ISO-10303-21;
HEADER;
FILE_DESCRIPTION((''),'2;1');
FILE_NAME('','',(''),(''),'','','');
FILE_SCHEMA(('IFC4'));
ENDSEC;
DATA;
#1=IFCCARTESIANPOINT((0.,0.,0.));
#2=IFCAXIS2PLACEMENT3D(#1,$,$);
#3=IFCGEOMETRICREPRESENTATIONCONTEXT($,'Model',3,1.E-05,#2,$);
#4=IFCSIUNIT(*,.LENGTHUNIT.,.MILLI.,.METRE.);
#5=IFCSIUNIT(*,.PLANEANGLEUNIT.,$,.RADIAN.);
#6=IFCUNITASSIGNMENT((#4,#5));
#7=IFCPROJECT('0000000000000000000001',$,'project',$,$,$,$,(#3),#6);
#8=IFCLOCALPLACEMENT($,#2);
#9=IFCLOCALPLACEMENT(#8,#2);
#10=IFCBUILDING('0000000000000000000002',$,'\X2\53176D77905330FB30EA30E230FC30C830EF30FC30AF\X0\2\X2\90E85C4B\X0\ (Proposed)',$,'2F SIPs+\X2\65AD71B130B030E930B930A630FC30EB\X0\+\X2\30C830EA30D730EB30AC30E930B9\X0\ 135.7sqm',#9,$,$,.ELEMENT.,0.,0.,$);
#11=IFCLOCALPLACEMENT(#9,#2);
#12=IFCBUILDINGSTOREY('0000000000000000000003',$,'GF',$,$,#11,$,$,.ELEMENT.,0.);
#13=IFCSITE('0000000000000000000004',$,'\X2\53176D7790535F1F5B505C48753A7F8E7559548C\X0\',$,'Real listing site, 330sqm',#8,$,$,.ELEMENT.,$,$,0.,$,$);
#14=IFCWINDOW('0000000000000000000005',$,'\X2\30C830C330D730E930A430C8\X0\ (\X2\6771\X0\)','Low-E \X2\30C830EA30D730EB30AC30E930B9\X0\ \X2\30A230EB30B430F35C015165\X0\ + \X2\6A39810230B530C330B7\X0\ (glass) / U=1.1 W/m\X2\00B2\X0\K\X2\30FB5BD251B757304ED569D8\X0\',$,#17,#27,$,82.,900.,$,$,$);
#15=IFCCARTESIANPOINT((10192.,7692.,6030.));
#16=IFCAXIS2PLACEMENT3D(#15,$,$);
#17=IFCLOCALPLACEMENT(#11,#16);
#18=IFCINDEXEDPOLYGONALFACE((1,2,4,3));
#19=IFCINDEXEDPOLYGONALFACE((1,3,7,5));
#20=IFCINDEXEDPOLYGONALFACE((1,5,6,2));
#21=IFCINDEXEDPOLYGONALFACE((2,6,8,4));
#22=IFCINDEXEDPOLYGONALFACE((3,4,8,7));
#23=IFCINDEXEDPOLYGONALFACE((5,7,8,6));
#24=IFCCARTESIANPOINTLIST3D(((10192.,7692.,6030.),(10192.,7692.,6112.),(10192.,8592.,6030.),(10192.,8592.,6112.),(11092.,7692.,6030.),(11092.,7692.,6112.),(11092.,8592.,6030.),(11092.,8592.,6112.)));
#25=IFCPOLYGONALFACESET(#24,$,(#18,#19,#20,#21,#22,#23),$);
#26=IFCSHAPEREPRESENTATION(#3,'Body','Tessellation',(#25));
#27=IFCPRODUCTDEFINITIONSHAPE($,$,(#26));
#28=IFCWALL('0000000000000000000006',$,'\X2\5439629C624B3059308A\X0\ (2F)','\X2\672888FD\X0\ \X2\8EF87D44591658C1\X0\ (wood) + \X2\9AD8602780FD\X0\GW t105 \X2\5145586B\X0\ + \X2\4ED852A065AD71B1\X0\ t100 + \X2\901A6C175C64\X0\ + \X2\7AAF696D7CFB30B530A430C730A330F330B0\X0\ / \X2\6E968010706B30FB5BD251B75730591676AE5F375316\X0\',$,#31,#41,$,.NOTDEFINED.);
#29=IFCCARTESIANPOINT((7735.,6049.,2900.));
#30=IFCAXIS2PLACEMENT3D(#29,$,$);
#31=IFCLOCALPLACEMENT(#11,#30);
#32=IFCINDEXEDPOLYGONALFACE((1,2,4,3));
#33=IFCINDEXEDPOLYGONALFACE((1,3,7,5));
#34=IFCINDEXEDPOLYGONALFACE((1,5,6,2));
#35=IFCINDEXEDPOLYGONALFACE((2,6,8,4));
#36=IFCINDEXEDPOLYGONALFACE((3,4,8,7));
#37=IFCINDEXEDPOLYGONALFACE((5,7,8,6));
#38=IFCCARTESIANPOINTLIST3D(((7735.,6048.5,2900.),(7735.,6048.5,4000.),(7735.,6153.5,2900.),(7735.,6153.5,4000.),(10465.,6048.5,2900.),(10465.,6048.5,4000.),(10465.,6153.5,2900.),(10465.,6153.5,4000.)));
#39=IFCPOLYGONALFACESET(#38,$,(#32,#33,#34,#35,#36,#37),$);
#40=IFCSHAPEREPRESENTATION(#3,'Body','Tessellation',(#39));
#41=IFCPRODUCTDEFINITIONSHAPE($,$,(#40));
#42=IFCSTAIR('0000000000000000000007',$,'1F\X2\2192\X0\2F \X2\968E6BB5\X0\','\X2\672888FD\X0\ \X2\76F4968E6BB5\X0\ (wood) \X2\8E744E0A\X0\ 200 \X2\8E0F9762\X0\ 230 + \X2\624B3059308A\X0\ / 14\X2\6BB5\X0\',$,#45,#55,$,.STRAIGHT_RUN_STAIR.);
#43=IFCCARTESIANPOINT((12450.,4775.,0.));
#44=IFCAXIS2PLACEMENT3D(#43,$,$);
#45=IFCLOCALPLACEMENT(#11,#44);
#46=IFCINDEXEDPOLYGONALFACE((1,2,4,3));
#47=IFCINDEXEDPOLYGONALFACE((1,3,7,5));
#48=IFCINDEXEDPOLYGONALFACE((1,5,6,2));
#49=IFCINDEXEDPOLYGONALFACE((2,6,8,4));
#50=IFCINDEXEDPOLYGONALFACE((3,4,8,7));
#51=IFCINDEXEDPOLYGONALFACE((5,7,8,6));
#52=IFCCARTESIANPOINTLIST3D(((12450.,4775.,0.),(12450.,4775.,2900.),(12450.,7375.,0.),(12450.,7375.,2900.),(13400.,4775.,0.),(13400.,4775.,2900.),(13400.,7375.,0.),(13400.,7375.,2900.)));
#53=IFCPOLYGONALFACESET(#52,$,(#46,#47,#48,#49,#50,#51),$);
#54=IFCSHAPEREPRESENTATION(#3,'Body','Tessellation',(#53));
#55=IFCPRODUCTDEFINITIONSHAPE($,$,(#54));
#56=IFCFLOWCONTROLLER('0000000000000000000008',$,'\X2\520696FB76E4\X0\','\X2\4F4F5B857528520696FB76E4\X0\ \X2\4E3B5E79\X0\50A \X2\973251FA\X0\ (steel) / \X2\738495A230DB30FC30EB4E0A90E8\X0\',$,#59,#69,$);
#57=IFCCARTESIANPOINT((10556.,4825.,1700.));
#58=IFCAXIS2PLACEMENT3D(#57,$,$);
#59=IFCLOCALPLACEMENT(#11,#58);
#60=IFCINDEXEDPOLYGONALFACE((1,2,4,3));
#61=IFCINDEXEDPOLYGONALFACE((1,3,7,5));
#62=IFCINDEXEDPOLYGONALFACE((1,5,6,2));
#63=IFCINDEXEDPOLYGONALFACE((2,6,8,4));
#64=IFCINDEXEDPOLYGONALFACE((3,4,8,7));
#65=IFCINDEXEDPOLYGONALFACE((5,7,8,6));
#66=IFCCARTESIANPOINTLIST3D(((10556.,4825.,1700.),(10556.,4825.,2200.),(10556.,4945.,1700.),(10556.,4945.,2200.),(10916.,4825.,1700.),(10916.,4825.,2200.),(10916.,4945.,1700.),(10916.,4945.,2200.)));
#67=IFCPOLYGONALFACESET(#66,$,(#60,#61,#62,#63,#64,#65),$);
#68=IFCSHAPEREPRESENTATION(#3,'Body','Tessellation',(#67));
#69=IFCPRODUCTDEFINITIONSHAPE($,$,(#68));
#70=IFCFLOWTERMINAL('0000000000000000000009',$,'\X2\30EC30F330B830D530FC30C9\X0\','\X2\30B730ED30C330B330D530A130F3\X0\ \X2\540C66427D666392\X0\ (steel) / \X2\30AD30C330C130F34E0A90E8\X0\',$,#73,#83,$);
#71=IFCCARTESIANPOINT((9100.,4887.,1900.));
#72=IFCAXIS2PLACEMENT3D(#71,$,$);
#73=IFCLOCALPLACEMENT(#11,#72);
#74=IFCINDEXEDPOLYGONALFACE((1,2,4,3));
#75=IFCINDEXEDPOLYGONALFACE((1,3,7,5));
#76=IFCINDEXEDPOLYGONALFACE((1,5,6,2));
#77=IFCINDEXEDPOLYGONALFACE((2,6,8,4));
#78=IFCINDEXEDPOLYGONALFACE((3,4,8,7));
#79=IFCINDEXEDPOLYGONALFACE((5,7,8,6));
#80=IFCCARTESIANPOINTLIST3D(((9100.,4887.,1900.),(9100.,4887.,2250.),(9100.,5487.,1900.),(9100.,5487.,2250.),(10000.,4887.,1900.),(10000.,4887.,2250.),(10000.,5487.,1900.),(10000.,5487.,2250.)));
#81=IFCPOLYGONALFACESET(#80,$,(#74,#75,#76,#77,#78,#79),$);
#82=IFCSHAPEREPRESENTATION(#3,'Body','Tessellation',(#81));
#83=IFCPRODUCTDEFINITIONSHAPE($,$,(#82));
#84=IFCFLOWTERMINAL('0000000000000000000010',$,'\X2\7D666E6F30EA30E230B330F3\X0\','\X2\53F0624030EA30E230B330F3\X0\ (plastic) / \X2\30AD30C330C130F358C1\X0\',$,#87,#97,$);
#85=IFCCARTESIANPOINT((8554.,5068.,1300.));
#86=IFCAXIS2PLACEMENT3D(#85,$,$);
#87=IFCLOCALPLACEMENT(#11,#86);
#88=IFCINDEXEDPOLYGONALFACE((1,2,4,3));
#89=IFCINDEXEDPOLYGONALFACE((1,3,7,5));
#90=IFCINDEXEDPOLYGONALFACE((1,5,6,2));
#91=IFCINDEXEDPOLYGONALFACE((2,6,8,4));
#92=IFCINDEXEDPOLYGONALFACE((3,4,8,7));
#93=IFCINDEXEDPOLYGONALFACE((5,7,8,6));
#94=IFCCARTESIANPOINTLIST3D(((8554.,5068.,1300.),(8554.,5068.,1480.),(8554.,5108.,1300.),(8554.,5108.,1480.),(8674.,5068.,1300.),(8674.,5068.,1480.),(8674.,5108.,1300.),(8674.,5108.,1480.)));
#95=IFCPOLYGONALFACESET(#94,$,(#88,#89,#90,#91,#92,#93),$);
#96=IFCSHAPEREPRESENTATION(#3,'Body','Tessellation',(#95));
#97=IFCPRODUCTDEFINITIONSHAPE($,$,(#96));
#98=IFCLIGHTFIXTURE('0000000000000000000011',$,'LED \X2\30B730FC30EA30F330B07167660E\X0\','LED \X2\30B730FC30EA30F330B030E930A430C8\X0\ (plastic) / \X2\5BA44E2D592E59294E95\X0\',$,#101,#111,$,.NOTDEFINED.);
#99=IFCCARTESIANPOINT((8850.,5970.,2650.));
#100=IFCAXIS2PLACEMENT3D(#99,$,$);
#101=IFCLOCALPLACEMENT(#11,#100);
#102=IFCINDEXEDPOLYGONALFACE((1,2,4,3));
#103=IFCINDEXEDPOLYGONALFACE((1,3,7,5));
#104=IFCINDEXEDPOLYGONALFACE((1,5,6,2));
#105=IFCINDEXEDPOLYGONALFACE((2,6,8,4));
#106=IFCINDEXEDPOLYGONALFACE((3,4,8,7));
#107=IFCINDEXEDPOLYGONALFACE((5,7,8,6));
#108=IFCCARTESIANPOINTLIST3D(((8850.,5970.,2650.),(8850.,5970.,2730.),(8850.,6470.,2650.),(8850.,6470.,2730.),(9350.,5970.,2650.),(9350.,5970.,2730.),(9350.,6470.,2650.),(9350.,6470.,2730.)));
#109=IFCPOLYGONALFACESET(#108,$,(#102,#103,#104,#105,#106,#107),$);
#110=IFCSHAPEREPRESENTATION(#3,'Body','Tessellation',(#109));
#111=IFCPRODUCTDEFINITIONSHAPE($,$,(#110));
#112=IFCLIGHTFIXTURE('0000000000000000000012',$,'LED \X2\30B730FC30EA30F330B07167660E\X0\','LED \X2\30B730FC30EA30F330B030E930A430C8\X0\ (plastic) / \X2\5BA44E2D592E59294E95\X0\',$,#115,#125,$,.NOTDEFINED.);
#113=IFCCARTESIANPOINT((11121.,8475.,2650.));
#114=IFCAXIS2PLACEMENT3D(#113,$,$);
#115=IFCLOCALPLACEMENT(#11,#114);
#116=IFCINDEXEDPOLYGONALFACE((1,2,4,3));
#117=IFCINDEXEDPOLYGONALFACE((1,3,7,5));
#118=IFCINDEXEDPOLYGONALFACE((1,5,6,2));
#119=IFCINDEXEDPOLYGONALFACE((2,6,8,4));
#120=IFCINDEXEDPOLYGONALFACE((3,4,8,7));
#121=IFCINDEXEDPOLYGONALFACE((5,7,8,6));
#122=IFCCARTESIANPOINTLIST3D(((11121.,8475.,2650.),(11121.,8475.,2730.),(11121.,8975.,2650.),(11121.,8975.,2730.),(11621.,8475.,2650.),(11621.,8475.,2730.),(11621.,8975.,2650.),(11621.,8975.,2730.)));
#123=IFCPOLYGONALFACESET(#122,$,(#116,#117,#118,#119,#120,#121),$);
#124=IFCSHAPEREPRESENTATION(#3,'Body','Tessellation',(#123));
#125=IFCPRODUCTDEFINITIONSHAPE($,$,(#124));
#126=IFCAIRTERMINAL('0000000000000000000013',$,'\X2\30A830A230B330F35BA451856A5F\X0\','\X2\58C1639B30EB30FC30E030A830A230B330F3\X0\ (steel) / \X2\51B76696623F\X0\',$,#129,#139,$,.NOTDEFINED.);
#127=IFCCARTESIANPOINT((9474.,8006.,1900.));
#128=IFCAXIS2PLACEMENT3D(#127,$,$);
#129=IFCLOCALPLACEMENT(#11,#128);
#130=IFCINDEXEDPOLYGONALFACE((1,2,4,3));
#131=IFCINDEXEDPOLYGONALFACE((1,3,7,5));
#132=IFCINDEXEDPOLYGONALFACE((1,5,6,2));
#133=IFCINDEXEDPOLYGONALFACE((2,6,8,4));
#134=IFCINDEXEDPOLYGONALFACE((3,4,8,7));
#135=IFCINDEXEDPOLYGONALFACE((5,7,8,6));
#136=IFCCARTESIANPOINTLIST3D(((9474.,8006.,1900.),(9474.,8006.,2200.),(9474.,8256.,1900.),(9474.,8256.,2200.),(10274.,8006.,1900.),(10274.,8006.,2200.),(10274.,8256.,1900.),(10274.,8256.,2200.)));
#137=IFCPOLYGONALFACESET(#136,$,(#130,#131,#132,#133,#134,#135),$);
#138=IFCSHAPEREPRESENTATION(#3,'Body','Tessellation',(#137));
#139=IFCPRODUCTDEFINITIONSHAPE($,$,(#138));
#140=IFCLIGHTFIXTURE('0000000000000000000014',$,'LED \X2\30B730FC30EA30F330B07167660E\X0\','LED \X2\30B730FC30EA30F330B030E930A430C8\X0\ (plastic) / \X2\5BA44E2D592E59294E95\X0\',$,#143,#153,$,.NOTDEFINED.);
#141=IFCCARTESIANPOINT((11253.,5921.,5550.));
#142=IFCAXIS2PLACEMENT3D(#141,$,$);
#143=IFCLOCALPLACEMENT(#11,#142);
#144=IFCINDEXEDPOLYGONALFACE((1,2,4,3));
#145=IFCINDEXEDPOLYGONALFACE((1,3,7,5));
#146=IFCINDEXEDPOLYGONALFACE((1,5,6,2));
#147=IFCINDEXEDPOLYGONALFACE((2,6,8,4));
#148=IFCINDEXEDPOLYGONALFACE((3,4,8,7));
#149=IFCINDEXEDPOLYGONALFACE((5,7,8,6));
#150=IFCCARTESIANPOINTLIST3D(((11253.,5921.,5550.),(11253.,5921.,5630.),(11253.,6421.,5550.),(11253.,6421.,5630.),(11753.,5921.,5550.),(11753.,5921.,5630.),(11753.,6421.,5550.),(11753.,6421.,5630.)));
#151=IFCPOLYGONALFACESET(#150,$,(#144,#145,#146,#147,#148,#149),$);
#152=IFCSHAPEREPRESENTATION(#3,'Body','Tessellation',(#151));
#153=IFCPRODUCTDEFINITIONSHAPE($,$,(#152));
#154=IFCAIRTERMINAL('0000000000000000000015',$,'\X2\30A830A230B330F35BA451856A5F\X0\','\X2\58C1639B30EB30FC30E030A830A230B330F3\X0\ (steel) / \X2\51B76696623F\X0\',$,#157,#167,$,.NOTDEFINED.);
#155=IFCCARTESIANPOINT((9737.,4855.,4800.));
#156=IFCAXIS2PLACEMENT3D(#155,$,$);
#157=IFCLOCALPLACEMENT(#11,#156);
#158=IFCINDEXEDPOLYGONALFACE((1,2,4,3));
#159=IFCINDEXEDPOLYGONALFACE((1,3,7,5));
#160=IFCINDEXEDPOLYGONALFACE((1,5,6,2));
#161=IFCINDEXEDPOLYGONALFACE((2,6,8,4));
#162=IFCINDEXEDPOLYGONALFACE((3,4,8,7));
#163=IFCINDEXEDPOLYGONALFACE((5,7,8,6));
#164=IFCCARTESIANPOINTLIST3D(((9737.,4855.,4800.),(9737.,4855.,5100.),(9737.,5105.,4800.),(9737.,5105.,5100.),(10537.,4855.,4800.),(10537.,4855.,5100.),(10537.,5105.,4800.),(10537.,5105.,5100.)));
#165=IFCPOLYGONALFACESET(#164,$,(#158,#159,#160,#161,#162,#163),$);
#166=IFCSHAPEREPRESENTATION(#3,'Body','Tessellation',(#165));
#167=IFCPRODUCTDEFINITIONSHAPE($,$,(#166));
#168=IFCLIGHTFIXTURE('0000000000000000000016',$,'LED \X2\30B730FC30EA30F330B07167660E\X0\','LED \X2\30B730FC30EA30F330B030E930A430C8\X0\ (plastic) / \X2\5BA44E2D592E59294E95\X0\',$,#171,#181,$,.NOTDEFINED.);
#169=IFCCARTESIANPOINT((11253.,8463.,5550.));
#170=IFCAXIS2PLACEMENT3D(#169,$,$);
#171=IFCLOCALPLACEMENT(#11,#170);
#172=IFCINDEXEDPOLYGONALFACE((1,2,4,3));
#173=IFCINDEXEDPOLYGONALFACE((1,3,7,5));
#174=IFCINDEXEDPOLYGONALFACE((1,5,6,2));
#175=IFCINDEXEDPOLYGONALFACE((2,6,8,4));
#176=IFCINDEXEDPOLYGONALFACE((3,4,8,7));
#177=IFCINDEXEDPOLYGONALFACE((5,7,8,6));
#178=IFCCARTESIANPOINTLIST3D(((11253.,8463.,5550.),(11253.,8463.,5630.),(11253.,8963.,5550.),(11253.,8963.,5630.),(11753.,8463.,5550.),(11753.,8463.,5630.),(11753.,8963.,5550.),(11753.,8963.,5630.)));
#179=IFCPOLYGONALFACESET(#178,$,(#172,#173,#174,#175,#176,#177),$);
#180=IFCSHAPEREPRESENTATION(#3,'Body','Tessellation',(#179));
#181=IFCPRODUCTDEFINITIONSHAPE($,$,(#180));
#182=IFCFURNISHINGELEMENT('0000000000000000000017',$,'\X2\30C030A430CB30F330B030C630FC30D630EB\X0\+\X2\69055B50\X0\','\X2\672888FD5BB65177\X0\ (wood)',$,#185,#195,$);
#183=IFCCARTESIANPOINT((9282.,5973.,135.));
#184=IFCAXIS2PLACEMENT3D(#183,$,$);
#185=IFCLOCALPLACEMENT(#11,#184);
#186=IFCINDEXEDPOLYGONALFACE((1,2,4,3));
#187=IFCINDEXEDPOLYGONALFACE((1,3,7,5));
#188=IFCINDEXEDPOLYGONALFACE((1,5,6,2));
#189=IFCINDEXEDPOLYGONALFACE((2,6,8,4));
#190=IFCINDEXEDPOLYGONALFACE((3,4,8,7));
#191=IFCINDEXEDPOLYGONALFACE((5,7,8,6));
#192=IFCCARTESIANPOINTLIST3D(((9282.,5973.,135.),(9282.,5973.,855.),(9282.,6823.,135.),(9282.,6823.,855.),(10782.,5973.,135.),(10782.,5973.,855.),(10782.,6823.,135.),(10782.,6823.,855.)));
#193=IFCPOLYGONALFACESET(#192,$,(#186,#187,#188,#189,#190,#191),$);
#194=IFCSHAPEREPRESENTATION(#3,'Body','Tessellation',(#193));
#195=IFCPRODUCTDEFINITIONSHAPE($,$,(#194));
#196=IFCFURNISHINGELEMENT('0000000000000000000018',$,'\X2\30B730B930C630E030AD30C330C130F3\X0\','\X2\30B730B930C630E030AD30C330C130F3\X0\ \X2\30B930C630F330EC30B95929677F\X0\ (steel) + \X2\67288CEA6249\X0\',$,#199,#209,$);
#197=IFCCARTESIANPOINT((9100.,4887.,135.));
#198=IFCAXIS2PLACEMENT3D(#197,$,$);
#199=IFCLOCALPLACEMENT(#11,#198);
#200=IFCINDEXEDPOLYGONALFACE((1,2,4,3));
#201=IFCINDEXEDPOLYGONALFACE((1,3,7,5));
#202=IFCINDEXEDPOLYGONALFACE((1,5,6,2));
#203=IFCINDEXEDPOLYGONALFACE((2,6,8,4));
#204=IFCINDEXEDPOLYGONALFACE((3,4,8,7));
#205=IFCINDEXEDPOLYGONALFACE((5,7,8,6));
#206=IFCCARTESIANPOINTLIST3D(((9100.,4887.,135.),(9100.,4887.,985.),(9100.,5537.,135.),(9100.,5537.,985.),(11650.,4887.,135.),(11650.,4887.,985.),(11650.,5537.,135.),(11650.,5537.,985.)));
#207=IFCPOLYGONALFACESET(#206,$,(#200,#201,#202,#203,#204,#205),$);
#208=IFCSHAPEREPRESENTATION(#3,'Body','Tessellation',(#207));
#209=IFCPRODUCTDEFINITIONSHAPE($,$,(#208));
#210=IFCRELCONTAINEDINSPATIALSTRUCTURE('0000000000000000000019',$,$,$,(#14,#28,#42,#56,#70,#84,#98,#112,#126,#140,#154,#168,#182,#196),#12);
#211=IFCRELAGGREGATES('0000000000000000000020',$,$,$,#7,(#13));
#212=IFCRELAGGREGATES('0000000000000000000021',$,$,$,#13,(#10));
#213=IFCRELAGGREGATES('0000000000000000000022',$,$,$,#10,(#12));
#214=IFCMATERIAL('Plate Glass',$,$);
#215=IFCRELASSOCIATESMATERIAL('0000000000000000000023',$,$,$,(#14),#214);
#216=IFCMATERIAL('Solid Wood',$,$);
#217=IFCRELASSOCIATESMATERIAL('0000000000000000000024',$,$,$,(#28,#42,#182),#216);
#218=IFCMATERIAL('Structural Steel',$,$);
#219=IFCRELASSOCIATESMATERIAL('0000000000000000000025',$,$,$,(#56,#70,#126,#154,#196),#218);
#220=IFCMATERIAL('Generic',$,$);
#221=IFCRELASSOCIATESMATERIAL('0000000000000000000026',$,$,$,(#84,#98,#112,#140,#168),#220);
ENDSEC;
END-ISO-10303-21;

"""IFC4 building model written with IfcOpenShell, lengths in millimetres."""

from ifc_helpers import new_model, si_unit, frame, frame_2d, origin, place, context, project, spatial, rectangle, extrude, material, element, save


model = new_model("IFC4")

# Units and contexts
model_context = context("Model", 3, precision=1e-05, world=origin())
ifc_project = project(units=[si_unit("LENGTHUNIT", "METRE", prefix="MILLI"), si_unit("PLANEANGLEUNIT", "RADIAN")], contexts=[model_context])

# Site, building, storey
site_placement = place(None, origin())
site = spatial("IfcSite", under=ifc_project, at=site_placement, Name="北海道弟子屈町美留和", ObjectType="Real listing site, 330sqm", CompositionType="ELEMENT", RefElevation=0.0)
building_placement = place(site_placement, origin())
building = spatial("IfcBuilding", under=site, at=building_placement, Name="北海道・リモートワーク2部屋 (Proposed)", ObjectType="2F SIPs+断熱グラスウール+トリプルガラス 135.7sqm", CompositionType="ELEMENT", ElevationOfRefHeight=0.0, ElevationOfTerrain=0.0)
storey_placement = place(building_placement, origin())
storey = spatial("IfcBuildingStorey", under=building, at=storey_placement, Name="GF", CompositionType="ELEMENT", Elevation=0.0)

# Shared definitions
ifc_material_1 = material(Name="Solid Wood")

# Window
ifc_material_2 = material(Name="Plate Glass")
window_placement = place(storey_placement, frame((10192.0, 7692.0, 6030.0)))
element("IfcWindow", 1, at=window_placement, inside=storey, material=ifc_material_2, Name="トップライト (東)", Description="Low-E トリプルガラス アルゴン封入 + 樹脂サッシ (glass) / U=1.1 W/m²K・寒冷地仕様", OverallHeight=82.0, OverallWidth=900.0, context=model_context, shape_type="SweptSolid", body=[
    extrude(rectangle(XDim=900.0, YDim=900.0, at=frame_2d((450.0, 450.0))), frame((10192.0, 7692.0, 6030.0)), (0.0, 0.0, 1.0), 82.0),
])

# Wall
wall_1_placement = place(storey_placement, frame((7735.0, 6049.0, 2900.0)))
element("IfcWall", 2, at=wall_1_placement, inside=storey, material=ifc_material_1, Name="吹抜手すり (2F)", Description="木製 軸組外壁 (wood) + 高性能GW t105 充填 + 付加断熱 t100 + 通気層 + 窯業系サイディング / 準耐火・寒冷地外皮強化", PredefinedType="NOTDEFINED", context=model_context, shape_type="SweptSolid", body=[
    extrude(rectangle(XDim=2730.0, YDim=105.0, at=frame_2d((1365.0, 52.0))), frame((7735.0, 6049.0, 2900.0)), (0.0, 0.0, 1.0), 1100.0),
])

# Stair
stair_placement = place(storey_placement, frame((12450.0, 4775.0, 0.0)))
element("IfcStair", 3, at=stair_placement, inside=storey, material=ifc_material_1, Name="1F→2F 階段", Description="木製 直階段 (wood) 蹴上 200 踏面 230 + 手すり / 14段", PredefinedType="STRAIGHT_RUN_STAIR", context=model_context, shape_type="SweptSolid", body=[
    extrude(rectangle(XDim=950.0, YDim=2600.0, at=frame_2d((475.0, 1300.0))), frame((12450.0, 4775.0, 0.0)), (0.0, 0.0, 1.0), 2900.0),
])

# Flow controller
ifc_material_3 = material(Name="Structural Steel")
flow_controller_placement = place(storey_placement, frame((10556.0, 4825.0, 1700.0)))
element("IfcFlowController", 4, at=flow_controller_placement, inside=storey, material=ifc_material_3, Name="分電盤", Description="住宅用分電盤 主幹50A 露出 (steel) / 玄関ホール上部", context=model_context, shape_type="SweptSolid", body=[
    extrude(rectangle(XDim=360.0, YDim=120.0, at=frame_2d((180.0, 60.0))), frame((10556.0, 4825.0, 1700.0)), (0.0, 0.0, 1.0), 500.0),
])

# Flow terminals
flow_terminal_1_placement = place(storey_placement, frame((9100.0, 4887.0, 1900.0)))
element("IfcFlowTerminal", 5, at=flow_terminal_1_placement, inside=storey, material=ifc_material_3, Name="レンジフード", Description="シロッコファン 同時給排 (steel) / キッチン上部", context=model_context, shape_type="SweptSolid", body=[
    extrude(rectangle(XDim=900.0, YDim=600.0, at=frame_2d((450.0, 300.0))), frame((9100.0, 4887.0, 1900.0)), (0.0, 0.0, 1.0), 350.0),
])
ifc_material_4 = material(Name="Generic")
flow_terminal_2_placement = place(storey_placement, frame((8554.0, 5068.0, 1300.0)))
element("IfcFlowTerminal", 6, at=flow_terminal_2_placement, inside=storey, material=ifc_material_4, Name="給湯リモコン", Description="台所リモコン (plastic) / キッチン壁", context=model_context, shape_type="SweptSolid", body=[
    extrude(rectangle(XDim=120.0, YDim=40.0, at=frame_2d((60.0, 20.0))), frame((8554.0, 5068.0, 1300.0)), (0.0, 0.0, 1.0), 180.0),
])

# Light fixtures
light_fixture_1_placement = place(storey_placement, frame((8850.0, 5970.0, 2650.0)))
element("IfcLightFixture", 7, at=light_fixture_1_placement, inside=storey, material=ifc_material_4, Name="LED シーリング照明", Description="LED シーリングライト (plastic) / 室中央天井", PredefinedType="NOTDEFINED", context=model_context, shape_type="SweptSolid", body=[
    extrude(rectangle(XDim=500.0, YDim=500.0, at=frame_2d((250.0, 250.0))), frame((8850.0, 5970.0, 2650.0)), (0.0, 0.0, 1.0), 80.0),
])
light_fixture_2_placement = place(storey_placement, frame((11121.0, 8475.0, 2650.0)))
element("IfcLightFixture", 8, at=light_fixture_2_placement, inside=storey, material=ifc_material_4, Name="LED シーリング照明", Description="LED シーリングライト (plastic) / 室中央天井", PredefinedType="NOTDEFINED", context=model_context, shape_type="SweptSolid", body=[
    extrude(rectangle(XDim=500.0, YDim=500.0, at=frame_2d((250.0, 250.0))), frame((11121.0, 8475.0, 2650.0)), (0.0, 0.0, 1.0), 80.0),
])

# Air terminal
air_terminal_1_placement = place(storey_placement, frame((9474.0, 8006.0, 1900.0)))
element("IfcAirTerminal", 9, at=air_terminal_1_placement, inside=storey, material=ifc_material_3, Name="エアコン室内機", Description="壁掛ルームエアコン (steel) / 冷暖房", PredefinedType="NOTDEFINED", context=model_context, shape_type="SweptSolid", body=[
    extrude(rectangle(XDim=800.0, YDim=250.0, at=frame_2d((400.0, 125.0))), frame((9474.0, 8006.0, 1900.0)), (0.0, 0.0, 1.0), 300.0),
])

# Light fixture
light_fixture_3_placement = place(storey_placement, frame((11253.0, 5921.0, 5550.0)))
element("IfcLightFixture", 10, at=light_fixture_3_placement, inside=storey, material=ifc_material_4, Name="LED シーリング照明", Description="LED シーリングライト (plastic) / 室中央天井", PredefinedType="NOTDEFINED", context=model_context, shape_type="SweptSolid", body=[
    extrude(rectangle(XDim=500.0, YDim=500.0, at=frame_2d((250.0, 250.0))), frame((11253.0, 5921.0, 5550.0)), (0.0, 0.0, 1.0), 80.0),
])

# Air terminal
air_terminal_2_placement = place(storey_placement, frame((9737.0, 4855.0, 4800.0)))
element("IfcAirTerminal", 11, at=air_terminal_2_placement, inside=storey, material=ifc_material_3, Name="エアコン室内機", Description="壁掛ルームエアコン (steel) / 冷暖房", PredefinedType="NOTDEFINED", context=model_context, shape_type="SweptSolid", body=[
    extrude(rectangle(XDim=800.0, YDim=250.0, at=frame_2d((400.0, 125.0))), frame((9737.0, 4855.0, 4800.0)), (0.0, 0.0, 1.0), 300.0),
])

# Light fixture
light_fixture_4_placement = place(storey_placement, frame((11253.0, 8463.0, 5550.0)))
element("IfcLightFixture", 12, at=light_fixture_4_placement, inside=storey, material=ifc_material_4, Name="LED シーリング照明", Description="LED シーリングライト (plastic) / 室中央天井", PredefinedType="NOTDEFINED", context=model_context, shape_type="SweptSolid", body=[
    extrude(rectangle(XDim=500.0, YDim=500.0, at=frame_2d((250.0, 250.0))), frame((11253.0, 8463.0, 5550.0)), (0.0, 0.0, 1.0), 80.0),
])

# Furnishing elements
furnishing_1_placement = place(storey_placement, frame((9282.0, 5973.0, 135.0)))
element("IfcFurnishingElement", 13, at=furnishing_1_placement, inside=storey, material=ifc_material_1, Name="ダイニングテーブル+椅子", Description="木製家具 (wood)", context=model_context, shape_type="SweptSolid", body=[
    extrude(rectangle(XDim=1500.0, YDim=850.0, at=frame_2d((750.0, 425.0))), frame((9282.0, 5973.0, 135.0)), (0.0, 0.0, 1.0), 720.0),
])
furnishing_2_placement = place(storey_placement, frame((9100.0, 4887.0, 135.0)))
element("IfcFurnishingElement", 14, at=furnishing_2_placement, inside=storey, material=ifc_material_3, Name="システムキッチン", Description="システムキッチン ステンレス天板 (steel) + 木質扉", context=model_context, shape_type="SweptSolid", body=[
    extrude(rectangle(XDim=2550.0, YDim=650.0, at=frame_2d((1275.0, 325.0))), frame((9100.0, 4887.0, 135.0)), (0.0, 0.0, 1.0), 850.0),
])

save(model, "model.ifc")
